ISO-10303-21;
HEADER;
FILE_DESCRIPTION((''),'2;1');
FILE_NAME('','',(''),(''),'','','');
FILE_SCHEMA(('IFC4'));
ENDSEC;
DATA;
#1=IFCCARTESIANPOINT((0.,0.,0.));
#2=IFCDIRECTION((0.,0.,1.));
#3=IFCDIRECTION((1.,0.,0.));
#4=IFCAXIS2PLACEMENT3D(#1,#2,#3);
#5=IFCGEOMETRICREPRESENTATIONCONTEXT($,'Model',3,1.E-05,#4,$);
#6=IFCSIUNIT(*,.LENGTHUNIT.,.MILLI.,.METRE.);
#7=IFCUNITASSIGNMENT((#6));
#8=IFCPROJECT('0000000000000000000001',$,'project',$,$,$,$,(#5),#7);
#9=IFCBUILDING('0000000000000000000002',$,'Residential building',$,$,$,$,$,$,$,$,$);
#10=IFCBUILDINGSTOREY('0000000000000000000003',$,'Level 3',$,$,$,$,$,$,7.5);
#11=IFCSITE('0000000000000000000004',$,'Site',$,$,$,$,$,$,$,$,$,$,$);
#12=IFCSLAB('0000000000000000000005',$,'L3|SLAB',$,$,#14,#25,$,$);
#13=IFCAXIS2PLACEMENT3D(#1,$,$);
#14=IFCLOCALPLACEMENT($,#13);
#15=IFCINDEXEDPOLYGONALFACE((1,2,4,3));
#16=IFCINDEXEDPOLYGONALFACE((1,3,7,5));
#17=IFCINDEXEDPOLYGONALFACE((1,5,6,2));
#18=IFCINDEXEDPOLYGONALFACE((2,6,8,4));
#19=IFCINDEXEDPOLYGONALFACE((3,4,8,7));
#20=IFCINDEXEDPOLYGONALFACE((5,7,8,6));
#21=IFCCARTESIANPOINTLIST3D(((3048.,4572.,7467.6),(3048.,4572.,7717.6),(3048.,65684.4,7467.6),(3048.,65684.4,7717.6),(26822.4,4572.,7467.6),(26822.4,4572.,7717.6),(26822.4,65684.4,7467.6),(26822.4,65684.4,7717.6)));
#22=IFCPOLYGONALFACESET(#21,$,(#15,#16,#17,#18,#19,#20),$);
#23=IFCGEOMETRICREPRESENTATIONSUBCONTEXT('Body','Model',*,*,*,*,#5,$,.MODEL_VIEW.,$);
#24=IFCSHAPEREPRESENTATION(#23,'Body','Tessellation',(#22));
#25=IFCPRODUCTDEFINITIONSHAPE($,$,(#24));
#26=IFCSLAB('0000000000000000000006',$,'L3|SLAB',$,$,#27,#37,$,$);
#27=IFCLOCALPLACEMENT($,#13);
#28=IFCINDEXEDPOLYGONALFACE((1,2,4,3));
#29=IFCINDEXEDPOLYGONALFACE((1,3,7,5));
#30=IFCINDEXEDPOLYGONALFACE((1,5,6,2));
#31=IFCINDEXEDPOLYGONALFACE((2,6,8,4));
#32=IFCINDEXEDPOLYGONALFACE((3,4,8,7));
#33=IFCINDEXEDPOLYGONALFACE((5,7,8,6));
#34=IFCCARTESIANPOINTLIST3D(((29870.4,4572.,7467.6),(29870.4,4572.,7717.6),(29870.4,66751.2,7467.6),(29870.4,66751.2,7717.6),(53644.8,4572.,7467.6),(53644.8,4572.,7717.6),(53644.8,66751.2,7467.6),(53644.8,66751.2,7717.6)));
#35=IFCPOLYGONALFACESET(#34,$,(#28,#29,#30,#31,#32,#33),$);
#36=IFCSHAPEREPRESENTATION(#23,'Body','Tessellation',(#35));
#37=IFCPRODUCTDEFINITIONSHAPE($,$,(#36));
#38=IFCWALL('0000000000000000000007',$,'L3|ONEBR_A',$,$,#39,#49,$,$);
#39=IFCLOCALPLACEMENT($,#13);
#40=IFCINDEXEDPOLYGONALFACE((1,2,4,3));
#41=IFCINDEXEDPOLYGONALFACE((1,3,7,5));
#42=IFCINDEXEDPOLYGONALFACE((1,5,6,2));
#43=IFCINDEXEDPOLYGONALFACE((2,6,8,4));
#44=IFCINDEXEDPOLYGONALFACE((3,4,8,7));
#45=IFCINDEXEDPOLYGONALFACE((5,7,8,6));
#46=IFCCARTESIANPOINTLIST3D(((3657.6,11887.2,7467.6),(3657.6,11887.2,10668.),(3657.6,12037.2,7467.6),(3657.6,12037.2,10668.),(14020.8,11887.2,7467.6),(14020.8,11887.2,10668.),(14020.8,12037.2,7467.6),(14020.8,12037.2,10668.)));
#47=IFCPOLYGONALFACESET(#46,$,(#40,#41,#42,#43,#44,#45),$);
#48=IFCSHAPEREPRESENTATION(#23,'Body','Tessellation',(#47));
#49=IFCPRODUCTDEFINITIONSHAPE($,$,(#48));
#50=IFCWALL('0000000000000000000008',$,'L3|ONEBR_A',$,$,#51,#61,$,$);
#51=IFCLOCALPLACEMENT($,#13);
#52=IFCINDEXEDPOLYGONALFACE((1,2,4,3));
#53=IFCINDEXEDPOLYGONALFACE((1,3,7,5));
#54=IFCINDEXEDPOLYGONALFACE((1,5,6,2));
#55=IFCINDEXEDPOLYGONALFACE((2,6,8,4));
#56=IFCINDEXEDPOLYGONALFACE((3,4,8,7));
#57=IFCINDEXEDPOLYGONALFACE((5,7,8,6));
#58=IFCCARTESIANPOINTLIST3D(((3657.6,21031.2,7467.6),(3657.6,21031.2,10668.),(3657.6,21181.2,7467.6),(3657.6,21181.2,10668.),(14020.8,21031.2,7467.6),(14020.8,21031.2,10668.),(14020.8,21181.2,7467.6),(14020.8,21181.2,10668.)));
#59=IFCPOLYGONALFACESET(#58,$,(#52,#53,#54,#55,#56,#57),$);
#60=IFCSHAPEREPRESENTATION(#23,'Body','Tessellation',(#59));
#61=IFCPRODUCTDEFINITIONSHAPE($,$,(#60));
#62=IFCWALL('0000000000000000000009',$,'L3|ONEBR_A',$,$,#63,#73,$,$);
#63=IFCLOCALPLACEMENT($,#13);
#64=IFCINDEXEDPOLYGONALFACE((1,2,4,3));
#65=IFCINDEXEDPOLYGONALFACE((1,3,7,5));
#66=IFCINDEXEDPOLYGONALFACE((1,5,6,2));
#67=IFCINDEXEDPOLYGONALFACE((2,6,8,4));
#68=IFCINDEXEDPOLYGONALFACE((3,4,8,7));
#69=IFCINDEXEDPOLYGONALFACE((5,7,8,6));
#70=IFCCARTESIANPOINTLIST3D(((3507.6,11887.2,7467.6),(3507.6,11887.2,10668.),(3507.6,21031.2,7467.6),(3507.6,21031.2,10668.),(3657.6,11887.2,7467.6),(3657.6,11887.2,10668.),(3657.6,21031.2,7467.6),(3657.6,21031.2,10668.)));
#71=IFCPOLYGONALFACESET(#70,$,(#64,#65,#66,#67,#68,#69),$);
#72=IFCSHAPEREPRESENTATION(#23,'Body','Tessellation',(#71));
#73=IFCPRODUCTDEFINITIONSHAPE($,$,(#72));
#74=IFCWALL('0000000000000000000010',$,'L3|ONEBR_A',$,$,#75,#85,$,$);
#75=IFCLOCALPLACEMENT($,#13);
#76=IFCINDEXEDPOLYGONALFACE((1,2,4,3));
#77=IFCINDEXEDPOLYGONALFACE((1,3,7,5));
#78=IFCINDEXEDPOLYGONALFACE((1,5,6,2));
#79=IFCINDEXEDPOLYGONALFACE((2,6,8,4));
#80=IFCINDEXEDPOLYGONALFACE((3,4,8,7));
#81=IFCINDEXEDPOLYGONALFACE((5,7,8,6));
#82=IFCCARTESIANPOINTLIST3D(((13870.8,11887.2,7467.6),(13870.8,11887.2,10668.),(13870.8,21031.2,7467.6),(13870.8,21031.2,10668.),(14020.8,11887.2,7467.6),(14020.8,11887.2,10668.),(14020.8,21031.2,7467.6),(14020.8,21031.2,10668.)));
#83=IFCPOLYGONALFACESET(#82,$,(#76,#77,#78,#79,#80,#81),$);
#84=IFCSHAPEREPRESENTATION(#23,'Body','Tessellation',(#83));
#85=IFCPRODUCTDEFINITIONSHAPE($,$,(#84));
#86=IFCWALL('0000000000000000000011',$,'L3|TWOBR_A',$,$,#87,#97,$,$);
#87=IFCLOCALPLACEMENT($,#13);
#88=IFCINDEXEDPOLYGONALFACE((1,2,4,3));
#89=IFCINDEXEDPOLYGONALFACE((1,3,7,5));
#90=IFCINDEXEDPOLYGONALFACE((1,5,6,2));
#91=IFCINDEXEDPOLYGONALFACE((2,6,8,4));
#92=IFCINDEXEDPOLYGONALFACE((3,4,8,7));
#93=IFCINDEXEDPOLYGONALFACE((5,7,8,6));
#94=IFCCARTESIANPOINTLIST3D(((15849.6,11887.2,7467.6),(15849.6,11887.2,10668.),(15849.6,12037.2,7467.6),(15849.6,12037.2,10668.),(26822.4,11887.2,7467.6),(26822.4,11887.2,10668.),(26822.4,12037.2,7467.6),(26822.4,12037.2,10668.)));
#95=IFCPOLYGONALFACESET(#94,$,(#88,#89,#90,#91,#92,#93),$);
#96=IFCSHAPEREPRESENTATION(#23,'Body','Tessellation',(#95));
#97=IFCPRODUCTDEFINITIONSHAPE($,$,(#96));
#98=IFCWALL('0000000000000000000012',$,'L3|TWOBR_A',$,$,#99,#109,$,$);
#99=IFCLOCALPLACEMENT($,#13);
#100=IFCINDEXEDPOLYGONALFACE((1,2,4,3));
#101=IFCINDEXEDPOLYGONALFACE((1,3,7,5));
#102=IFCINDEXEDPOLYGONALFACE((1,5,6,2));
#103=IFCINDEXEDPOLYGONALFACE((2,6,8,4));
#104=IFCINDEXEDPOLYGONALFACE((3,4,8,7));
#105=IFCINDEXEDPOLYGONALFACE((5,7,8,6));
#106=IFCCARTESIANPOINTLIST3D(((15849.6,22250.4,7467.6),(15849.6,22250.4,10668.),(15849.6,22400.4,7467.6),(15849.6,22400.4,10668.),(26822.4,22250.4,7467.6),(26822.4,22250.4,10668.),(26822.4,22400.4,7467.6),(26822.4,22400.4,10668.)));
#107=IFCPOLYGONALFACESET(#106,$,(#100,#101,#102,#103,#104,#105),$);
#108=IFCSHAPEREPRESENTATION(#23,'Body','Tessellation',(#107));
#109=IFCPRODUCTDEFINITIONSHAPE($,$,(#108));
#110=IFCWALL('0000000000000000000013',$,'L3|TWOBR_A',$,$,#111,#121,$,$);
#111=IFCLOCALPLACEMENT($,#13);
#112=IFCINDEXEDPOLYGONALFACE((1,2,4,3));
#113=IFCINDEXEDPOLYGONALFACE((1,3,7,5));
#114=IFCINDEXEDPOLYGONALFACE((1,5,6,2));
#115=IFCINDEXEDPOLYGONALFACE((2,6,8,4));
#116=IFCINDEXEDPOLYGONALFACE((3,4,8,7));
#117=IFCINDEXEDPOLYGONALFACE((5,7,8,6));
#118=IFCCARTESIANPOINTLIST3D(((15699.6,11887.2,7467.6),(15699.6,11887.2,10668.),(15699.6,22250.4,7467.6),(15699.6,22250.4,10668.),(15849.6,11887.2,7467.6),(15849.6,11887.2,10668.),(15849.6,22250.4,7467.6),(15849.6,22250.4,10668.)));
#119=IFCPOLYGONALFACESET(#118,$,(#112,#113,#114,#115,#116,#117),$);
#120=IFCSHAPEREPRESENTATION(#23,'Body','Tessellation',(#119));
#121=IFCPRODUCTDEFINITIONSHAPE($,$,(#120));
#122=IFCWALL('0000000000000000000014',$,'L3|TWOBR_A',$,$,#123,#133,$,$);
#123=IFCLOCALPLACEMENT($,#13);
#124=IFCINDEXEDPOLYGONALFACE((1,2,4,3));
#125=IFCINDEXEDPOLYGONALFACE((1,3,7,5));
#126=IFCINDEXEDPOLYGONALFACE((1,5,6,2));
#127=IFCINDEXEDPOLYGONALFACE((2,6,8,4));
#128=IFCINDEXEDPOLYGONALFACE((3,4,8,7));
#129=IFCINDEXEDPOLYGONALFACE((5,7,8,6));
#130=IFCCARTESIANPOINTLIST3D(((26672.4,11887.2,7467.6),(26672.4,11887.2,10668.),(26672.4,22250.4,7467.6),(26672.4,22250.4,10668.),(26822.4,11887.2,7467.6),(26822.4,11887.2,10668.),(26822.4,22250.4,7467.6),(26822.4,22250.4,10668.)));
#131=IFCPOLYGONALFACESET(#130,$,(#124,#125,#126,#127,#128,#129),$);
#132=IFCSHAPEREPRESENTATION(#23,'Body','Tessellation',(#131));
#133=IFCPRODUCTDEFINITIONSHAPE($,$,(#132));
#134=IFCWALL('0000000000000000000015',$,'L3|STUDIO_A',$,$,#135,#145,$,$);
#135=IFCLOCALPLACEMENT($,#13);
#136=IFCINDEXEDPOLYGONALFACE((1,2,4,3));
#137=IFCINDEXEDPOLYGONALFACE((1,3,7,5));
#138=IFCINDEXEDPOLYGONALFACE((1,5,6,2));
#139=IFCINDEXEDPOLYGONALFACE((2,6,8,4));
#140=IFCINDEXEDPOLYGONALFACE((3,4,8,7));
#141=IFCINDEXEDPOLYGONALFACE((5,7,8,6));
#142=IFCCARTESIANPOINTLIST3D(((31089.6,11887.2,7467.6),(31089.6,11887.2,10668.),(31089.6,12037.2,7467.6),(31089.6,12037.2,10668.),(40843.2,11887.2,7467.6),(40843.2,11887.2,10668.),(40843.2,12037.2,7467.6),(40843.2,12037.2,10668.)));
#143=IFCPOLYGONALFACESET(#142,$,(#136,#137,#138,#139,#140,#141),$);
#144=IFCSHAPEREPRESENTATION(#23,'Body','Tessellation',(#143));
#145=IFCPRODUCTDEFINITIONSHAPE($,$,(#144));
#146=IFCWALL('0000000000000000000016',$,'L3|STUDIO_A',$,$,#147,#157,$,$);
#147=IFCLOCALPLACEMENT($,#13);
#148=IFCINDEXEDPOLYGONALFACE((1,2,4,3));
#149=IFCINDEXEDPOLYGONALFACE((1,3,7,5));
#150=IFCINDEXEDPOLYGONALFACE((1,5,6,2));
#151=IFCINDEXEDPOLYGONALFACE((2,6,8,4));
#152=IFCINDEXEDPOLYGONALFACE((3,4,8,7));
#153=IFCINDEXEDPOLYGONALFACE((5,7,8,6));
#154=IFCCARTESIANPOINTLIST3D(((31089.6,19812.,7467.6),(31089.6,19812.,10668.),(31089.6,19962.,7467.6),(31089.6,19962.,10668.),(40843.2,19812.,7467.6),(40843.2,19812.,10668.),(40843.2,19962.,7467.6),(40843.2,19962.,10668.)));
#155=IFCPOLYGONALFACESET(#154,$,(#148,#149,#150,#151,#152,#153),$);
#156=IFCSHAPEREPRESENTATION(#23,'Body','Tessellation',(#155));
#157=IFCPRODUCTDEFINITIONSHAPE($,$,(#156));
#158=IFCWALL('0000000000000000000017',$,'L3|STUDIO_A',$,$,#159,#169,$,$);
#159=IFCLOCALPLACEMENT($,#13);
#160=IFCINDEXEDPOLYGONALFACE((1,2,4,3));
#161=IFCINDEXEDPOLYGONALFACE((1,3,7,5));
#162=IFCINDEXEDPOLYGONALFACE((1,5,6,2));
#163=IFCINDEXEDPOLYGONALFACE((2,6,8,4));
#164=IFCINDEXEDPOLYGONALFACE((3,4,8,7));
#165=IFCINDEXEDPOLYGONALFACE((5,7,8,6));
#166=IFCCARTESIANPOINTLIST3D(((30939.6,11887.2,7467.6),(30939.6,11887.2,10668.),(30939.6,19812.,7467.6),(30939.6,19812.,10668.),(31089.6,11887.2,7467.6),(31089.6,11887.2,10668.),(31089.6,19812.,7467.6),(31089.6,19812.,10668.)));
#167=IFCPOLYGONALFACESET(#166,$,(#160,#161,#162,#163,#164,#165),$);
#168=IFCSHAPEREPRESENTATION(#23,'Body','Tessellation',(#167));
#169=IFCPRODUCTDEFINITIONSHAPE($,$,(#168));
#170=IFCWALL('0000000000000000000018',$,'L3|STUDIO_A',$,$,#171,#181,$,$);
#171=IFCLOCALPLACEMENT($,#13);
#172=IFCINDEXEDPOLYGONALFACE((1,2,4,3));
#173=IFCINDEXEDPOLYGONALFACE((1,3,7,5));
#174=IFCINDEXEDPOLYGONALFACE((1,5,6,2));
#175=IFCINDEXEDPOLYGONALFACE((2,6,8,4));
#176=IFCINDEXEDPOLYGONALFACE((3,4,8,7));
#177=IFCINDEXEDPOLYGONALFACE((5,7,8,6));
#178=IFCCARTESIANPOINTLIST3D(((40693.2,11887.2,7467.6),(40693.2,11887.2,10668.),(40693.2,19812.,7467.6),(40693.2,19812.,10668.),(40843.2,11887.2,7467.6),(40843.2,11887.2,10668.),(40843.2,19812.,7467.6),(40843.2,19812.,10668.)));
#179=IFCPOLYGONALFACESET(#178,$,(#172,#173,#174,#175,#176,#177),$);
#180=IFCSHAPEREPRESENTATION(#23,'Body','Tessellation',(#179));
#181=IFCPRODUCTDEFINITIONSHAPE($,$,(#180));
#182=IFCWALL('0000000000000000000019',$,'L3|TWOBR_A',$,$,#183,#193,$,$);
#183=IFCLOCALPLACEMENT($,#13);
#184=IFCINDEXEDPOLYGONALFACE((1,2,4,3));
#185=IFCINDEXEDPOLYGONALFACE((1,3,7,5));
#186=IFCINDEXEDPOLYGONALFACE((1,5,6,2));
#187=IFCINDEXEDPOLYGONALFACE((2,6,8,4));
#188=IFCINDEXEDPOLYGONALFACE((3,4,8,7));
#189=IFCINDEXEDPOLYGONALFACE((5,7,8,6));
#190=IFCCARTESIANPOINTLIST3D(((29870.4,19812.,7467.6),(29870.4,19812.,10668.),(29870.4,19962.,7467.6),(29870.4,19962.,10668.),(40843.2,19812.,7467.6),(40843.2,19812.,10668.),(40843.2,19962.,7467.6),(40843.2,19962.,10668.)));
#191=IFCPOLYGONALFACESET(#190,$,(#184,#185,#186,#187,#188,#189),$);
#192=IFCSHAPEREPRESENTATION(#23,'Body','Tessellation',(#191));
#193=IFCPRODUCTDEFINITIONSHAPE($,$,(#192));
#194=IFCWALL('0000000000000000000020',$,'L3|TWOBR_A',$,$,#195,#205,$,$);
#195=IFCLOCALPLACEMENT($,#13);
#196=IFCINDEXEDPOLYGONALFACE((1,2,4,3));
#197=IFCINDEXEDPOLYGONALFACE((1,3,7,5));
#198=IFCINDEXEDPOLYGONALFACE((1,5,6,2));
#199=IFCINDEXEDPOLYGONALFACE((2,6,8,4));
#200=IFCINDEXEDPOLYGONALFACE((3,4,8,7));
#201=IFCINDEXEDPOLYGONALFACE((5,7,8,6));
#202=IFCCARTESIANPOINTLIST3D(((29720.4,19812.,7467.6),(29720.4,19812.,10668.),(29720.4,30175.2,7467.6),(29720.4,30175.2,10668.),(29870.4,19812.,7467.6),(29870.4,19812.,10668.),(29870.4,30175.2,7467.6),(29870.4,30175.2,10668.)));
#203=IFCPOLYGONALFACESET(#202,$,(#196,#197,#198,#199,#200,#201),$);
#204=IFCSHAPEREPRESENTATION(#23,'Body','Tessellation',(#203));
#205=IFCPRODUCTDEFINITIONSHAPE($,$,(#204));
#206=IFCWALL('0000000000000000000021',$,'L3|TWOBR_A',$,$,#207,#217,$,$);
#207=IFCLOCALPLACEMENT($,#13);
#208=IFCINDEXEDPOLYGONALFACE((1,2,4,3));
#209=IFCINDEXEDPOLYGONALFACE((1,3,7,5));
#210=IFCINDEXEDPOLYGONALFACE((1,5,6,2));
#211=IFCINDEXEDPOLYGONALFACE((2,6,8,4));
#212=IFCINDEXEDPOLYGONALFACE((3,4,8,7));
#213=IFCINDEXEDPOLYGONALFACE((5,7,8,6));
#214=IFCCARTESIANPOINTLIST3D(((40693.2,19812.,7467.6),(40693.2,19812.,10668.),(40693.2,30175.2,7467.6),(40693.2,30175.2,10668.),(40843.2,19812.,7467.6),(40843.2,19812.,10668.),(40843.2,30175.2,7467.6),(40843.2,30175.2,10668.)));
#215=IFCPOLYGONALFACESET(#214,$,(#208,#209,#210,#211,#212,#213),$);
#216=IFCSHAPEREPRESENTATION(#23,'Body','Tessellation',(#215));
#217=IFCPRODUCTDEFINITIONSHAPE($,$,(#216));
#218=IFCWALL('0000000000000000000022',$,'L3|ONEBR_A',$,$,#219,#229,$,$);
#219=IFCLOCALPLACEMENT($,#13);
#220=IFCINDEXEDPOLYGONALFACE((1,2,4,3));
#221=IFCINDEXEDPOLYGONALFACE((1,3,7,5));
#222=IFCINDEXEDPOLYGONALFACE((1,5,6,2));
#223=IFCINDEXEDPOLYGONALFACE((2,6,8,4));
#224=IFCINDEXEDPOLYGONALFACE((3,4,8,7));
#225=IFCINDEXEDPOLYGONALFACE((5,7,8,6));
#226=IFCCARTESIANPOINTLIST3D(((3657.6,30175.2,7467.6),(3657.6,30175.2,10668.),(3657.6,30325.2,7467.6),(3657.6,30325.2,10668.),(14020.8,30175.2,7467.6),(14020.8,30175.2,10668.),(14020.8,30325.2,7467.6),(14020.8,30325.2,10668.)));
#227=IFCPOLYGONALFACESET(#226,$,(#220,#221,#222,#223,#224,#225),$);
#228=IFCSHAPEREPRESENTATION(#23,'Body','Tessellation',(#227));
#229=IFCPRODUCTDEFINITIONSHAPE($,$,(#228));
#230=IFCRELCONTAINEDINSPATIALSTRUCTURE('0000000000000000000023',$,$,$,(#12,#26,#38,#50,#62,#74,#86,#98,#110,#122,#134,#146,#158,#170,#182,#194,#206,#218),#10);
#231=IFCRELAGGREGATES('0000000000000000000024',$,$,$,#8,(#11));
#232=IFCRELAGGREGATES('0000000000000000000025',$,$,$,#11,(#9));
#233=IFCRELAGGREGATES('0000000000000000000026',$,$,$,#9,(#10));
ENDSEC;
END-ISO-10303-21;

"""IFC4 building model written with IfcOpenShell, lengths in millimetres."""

from ifc_helpers import new_model, si_unit, frame, origin_with_axes, place, context, subcontext, project, spatial, indexed_curve, outline, extrude, element, save


model = new_model("IFC4")

# Units and contexts
model_context = context("Model", 3, precision=1e-05, world=origin_with_axes())
body_context = subcontext(model_context, "Body", "Model", "MODEL_VIEW")
ifc_project = project(units=[si_unit("LENGTHUNIT", "METRE", prefix="MILLI")], contexts=[model_context])

# Site, building, storey
site = spatial("IfcSite", under=ifc_project, Name="Site")
building = spatial("IfcBuilding", under=site, Name="Residential building")
storey = spatial("IfcBuildingStorey", under=building, Name="Level 3", Elevation=7.5)

# Slabs
slab_1_placement = place(None, frame((3048.0, 4572.0, 7467.6), z_axis=(0.0, 0.0, 1.0), x_axis=(1.0, 0.0, 0.0)))
element("IfcSlab", 1, at=slab_1_placement, inside=storey, Name="L3|SLAB", context=body_context, shape_type="SweptSolid", body=[
    extrude(outline(indexed_curve([(0.0, 0.0), (23774.4, 0.0), (23774.4, 61112.4), (0.0, 61112.4), (0.0, 0.0)])), None, (0.0, 0.0, 1.0), 250.0),
])
slab_2_placement = place(None, frame((29870.4, 4572.0, 7467.6), z_axis=(0.0, 0.0, 1.0), x_axis=(1.0, 0.0, 0.0)))
element("IfcSlab", 2, at=slab_2_placement, inside=storey, Name="L3|SLAB", context=body_context, shape_type="SweptSolid", body=[
    extrude(outline(indexed_curve([(0.0, 0.0), (23774.4, 0.0), (23774.4, 62179.2), (0.0, 62179.2), (0.0, 0.0)])), None, (0.0, 0.0, 1.0), 250.0),
])

# Walls
for number, where, z_axis, x_axis, name in (
    (3, (3657.6, 11887.2, 7467.6), (0.0, 0.0, 1.0), (1.0, 0.0, 0.0), "L3|ONEBR_A"),
    (4, (3657.6, 21031.2, 7467.6), (0.0, 0.0, 1.0), (1.0, 0.0, 0.0), "L3|ONEBR_A"),
):
    element("IfcWall", number, at=place(None, frame(where, z_axis=z_axis, x_axis=x_axis)), inside=storey, Name=name, context=body_context, shape_type="SweptSolid", body=[
        extrude(outline(indexed_curve([(0.0, 0.0), (0.0, 150.0), (10363.2, 150.0), (10363.2, 0.0), (0.0, 0.0)], self_intersect=False)), origin_with_axes(), (0.0, 0.0, 1.0), 3200.4),
    ])
for number, where, z_axis, x_axis, name in (
    (5, (3657.6, 11887.2, 7467.6), (0.0, 0.0, 1.0), (0.0, 1.0, 0.0), "L3|ONEBR_A"),
    (6, (14020.8, 11887.2, 7467.6), (0.0, 0.0, 1.0), (0.0, 1.0, 0.0), "L3|ONEBR_A"),
):
    element("IfcWall", number, at=place(None, frame(where, z_axis=z_axis, x_axis=x_axis)), inside=storey, Name=name, context=body_context, shape_type="SweptSolid", body=[
        extrude(outline(indexed_curve([(0.0, 0.0), (0.0, 150.0), (9144.0, 150.0), (9144.0, 0.0), (0.0, 0.0)], self_intersect=False)), origin_with_axes(), (0.0, 0.0, 1.0), 3200.4),
    ])
for number, where, z_axis, x_axis, name in (
    (7, (15849.6, 11887.2, 7467.6), (0.0, 0.0, 1.0), (1.0, 0.0, 0.0), "L3|TWOBR_A"),
    (8, (15849.6, 22250.4, 7467.6), (0.0, 0.0, 1.0), (1.0, 0.0, 0.0), "L3|TWOBR_A"),
):
    element("IfcWall", number, at=place(None, frame(where, z_axis=z_axis, x_axis=x_axis)), inside=storey, Name=name, context=body_context, shape_type="SweptSolid", body=[
        extrude(outline(indexed_curve([(0.0, 0.0), (0.0, 150.0), (10972.8, 150.0), (10972.8, 0.0), (0.0, 0.0)], self_intersect=False)), origin_with_axes(), (0.0, 0.0, 1.0), 3200.4),
    ])
for number, where, z_axis, x_axis, name in (
    (9, (15849.6, 11887.2, 7467.6), (0.0, 0.0, 1.0), (0.0, 1.0, 0.0), "L3|TWOBR_A"),
    (10, (26822.4, 11887.2, 7467.6), (0.0, 0.0, 1.0), (0.0, 1.0, 0.0), "L3|TWOBR_A"),
):
    element("IfcWall", number, at=place(None, frame(where, z_axis=z_axis, x_axis=x_axis)), inside=storey, Name=name, context=body_context, shape_type="SweptSolid", body=[
        extrude(outline(indexed_curve([(0.0, 0.0), (0.0, 150.0), (10363.2, 150.0), (10363.2, 0.0), (0.0, 0.0)], self_intersect=False)), origin_with_axes(), (0.0, 0.0, 1.0), 3200.4),
    ])
for number, where, z_axis, x_axis, name in (
    (11, (31089.6, 11887.2, 7467.6), (0.0, 0.0, 1.0), (1.0, 0.0, 0.0), "L3|STUDIO_A"),
    (12, (31089.6, 19812.0, 7467.6), (0.0, 0.0, 1.0), (1.0, 0.0, 0.0), "L3|STUDIO_A"),
):
    element("IfcWall", number, at=place(None, frame(where, z_axis=z_axis, x_axis=x_axis)), inside=storey, Name=name, context=body_context, shape_type="SweptSolid", body=[
        extrude(outline(indexed_curve([(0.0, 0.0), (0.0, 150.0), (9753.6, 150.0), (9753.6, 0.0), (0.0, 0.0)], self_intersect=False)), origin_with_axes(), (0.0, 0.0, 1.0), 3200.4),
    ])
for number, where, z_axis, x_axis, name in (
    (13, (31089.6, 11887.2, 7467.6), (0.0, 0.0, 1.0), (0.0, 1.0, 0.0), "L3|STUDIO_A"),
    (14, (40843.2, 11887.2, 7467.6), (0.0, 0.0, 1.0), (0.0, 1.0, 0.0), "L3|STUDIO_A"),
):
    element("IfcWall", number, at=place(None, frame(where, z_axis=z_axis, x_axis=x_axis)), inside=storey, Name=name, context=body_context, shape_type="SweptSolid", body=[
        extrude(outline(indexed_curve([(0.0, 0.0), (0.0, 150.0), (7924.8, 150.0), (7924.8, 0.0), (0.0, 0.0)], self_intersect=False)), origin_with_axes(), (0.0, 0.0, 1.0), 3200.4),
    ])
wall_1_placement = place(None, frame((29870.4, 19812.0, 7467.6), z_axis=(0.0, 0.0, 1.0), x_axis=(1.0, 0.0, 0.0)))
element("IfcWall", 15, at=wall_1_placement, inside=storey, Name="L3|TWOBR_A", context=body_context, shape_type="SweptSolid", body=[
    extrude(outline(indexed_curve([(0.0, 0.0), (0.0, 150.0), (10972.8, 150.0), (10972.8, 0.0), (0.0, 0.0)], self_intersect=False)), origin_with_axes(), (0.0, 0.0, 1.0), 3200.4),
])
for number, where, z_axis, x_axis, name in (
    (16, (29870.4, 19812.0, 7467.6), (0.0, 0.0, 1.0), (0.0, 1.0, 0.0), "L3|TWOBR_A"),
    (17, (40843.2, 19812.0, 7467.6), (0.0, 0.0, 1.0), (0.0, 1.0, 0.0), "L3|TWOBR_A"),
    (18, (3657.6, 30175.2, 7467.6), (0.0, 0.0, 1.0), (1.0, 0.0, 0.0), "L3|ONEBR_A"),
):
    element("IfcWall", number, at=place(None, frame(where, z_axis=z_axis, x_axis=x_axis)), inside=storey, Name=name, context=body_context, shape_type="SweptSolid", body=[
        extrude(outline(indexed_curve([(0.0, 0.0), (0.0, 150.0), (10363.2, 150.0), (10363.2, 0.0), (0.0, 0.0)], self_intersect=False)), origin_with_axes(), (0.0, 0.0, 1.0), 3200.4),
    ])

save(model, "model.ifc")
